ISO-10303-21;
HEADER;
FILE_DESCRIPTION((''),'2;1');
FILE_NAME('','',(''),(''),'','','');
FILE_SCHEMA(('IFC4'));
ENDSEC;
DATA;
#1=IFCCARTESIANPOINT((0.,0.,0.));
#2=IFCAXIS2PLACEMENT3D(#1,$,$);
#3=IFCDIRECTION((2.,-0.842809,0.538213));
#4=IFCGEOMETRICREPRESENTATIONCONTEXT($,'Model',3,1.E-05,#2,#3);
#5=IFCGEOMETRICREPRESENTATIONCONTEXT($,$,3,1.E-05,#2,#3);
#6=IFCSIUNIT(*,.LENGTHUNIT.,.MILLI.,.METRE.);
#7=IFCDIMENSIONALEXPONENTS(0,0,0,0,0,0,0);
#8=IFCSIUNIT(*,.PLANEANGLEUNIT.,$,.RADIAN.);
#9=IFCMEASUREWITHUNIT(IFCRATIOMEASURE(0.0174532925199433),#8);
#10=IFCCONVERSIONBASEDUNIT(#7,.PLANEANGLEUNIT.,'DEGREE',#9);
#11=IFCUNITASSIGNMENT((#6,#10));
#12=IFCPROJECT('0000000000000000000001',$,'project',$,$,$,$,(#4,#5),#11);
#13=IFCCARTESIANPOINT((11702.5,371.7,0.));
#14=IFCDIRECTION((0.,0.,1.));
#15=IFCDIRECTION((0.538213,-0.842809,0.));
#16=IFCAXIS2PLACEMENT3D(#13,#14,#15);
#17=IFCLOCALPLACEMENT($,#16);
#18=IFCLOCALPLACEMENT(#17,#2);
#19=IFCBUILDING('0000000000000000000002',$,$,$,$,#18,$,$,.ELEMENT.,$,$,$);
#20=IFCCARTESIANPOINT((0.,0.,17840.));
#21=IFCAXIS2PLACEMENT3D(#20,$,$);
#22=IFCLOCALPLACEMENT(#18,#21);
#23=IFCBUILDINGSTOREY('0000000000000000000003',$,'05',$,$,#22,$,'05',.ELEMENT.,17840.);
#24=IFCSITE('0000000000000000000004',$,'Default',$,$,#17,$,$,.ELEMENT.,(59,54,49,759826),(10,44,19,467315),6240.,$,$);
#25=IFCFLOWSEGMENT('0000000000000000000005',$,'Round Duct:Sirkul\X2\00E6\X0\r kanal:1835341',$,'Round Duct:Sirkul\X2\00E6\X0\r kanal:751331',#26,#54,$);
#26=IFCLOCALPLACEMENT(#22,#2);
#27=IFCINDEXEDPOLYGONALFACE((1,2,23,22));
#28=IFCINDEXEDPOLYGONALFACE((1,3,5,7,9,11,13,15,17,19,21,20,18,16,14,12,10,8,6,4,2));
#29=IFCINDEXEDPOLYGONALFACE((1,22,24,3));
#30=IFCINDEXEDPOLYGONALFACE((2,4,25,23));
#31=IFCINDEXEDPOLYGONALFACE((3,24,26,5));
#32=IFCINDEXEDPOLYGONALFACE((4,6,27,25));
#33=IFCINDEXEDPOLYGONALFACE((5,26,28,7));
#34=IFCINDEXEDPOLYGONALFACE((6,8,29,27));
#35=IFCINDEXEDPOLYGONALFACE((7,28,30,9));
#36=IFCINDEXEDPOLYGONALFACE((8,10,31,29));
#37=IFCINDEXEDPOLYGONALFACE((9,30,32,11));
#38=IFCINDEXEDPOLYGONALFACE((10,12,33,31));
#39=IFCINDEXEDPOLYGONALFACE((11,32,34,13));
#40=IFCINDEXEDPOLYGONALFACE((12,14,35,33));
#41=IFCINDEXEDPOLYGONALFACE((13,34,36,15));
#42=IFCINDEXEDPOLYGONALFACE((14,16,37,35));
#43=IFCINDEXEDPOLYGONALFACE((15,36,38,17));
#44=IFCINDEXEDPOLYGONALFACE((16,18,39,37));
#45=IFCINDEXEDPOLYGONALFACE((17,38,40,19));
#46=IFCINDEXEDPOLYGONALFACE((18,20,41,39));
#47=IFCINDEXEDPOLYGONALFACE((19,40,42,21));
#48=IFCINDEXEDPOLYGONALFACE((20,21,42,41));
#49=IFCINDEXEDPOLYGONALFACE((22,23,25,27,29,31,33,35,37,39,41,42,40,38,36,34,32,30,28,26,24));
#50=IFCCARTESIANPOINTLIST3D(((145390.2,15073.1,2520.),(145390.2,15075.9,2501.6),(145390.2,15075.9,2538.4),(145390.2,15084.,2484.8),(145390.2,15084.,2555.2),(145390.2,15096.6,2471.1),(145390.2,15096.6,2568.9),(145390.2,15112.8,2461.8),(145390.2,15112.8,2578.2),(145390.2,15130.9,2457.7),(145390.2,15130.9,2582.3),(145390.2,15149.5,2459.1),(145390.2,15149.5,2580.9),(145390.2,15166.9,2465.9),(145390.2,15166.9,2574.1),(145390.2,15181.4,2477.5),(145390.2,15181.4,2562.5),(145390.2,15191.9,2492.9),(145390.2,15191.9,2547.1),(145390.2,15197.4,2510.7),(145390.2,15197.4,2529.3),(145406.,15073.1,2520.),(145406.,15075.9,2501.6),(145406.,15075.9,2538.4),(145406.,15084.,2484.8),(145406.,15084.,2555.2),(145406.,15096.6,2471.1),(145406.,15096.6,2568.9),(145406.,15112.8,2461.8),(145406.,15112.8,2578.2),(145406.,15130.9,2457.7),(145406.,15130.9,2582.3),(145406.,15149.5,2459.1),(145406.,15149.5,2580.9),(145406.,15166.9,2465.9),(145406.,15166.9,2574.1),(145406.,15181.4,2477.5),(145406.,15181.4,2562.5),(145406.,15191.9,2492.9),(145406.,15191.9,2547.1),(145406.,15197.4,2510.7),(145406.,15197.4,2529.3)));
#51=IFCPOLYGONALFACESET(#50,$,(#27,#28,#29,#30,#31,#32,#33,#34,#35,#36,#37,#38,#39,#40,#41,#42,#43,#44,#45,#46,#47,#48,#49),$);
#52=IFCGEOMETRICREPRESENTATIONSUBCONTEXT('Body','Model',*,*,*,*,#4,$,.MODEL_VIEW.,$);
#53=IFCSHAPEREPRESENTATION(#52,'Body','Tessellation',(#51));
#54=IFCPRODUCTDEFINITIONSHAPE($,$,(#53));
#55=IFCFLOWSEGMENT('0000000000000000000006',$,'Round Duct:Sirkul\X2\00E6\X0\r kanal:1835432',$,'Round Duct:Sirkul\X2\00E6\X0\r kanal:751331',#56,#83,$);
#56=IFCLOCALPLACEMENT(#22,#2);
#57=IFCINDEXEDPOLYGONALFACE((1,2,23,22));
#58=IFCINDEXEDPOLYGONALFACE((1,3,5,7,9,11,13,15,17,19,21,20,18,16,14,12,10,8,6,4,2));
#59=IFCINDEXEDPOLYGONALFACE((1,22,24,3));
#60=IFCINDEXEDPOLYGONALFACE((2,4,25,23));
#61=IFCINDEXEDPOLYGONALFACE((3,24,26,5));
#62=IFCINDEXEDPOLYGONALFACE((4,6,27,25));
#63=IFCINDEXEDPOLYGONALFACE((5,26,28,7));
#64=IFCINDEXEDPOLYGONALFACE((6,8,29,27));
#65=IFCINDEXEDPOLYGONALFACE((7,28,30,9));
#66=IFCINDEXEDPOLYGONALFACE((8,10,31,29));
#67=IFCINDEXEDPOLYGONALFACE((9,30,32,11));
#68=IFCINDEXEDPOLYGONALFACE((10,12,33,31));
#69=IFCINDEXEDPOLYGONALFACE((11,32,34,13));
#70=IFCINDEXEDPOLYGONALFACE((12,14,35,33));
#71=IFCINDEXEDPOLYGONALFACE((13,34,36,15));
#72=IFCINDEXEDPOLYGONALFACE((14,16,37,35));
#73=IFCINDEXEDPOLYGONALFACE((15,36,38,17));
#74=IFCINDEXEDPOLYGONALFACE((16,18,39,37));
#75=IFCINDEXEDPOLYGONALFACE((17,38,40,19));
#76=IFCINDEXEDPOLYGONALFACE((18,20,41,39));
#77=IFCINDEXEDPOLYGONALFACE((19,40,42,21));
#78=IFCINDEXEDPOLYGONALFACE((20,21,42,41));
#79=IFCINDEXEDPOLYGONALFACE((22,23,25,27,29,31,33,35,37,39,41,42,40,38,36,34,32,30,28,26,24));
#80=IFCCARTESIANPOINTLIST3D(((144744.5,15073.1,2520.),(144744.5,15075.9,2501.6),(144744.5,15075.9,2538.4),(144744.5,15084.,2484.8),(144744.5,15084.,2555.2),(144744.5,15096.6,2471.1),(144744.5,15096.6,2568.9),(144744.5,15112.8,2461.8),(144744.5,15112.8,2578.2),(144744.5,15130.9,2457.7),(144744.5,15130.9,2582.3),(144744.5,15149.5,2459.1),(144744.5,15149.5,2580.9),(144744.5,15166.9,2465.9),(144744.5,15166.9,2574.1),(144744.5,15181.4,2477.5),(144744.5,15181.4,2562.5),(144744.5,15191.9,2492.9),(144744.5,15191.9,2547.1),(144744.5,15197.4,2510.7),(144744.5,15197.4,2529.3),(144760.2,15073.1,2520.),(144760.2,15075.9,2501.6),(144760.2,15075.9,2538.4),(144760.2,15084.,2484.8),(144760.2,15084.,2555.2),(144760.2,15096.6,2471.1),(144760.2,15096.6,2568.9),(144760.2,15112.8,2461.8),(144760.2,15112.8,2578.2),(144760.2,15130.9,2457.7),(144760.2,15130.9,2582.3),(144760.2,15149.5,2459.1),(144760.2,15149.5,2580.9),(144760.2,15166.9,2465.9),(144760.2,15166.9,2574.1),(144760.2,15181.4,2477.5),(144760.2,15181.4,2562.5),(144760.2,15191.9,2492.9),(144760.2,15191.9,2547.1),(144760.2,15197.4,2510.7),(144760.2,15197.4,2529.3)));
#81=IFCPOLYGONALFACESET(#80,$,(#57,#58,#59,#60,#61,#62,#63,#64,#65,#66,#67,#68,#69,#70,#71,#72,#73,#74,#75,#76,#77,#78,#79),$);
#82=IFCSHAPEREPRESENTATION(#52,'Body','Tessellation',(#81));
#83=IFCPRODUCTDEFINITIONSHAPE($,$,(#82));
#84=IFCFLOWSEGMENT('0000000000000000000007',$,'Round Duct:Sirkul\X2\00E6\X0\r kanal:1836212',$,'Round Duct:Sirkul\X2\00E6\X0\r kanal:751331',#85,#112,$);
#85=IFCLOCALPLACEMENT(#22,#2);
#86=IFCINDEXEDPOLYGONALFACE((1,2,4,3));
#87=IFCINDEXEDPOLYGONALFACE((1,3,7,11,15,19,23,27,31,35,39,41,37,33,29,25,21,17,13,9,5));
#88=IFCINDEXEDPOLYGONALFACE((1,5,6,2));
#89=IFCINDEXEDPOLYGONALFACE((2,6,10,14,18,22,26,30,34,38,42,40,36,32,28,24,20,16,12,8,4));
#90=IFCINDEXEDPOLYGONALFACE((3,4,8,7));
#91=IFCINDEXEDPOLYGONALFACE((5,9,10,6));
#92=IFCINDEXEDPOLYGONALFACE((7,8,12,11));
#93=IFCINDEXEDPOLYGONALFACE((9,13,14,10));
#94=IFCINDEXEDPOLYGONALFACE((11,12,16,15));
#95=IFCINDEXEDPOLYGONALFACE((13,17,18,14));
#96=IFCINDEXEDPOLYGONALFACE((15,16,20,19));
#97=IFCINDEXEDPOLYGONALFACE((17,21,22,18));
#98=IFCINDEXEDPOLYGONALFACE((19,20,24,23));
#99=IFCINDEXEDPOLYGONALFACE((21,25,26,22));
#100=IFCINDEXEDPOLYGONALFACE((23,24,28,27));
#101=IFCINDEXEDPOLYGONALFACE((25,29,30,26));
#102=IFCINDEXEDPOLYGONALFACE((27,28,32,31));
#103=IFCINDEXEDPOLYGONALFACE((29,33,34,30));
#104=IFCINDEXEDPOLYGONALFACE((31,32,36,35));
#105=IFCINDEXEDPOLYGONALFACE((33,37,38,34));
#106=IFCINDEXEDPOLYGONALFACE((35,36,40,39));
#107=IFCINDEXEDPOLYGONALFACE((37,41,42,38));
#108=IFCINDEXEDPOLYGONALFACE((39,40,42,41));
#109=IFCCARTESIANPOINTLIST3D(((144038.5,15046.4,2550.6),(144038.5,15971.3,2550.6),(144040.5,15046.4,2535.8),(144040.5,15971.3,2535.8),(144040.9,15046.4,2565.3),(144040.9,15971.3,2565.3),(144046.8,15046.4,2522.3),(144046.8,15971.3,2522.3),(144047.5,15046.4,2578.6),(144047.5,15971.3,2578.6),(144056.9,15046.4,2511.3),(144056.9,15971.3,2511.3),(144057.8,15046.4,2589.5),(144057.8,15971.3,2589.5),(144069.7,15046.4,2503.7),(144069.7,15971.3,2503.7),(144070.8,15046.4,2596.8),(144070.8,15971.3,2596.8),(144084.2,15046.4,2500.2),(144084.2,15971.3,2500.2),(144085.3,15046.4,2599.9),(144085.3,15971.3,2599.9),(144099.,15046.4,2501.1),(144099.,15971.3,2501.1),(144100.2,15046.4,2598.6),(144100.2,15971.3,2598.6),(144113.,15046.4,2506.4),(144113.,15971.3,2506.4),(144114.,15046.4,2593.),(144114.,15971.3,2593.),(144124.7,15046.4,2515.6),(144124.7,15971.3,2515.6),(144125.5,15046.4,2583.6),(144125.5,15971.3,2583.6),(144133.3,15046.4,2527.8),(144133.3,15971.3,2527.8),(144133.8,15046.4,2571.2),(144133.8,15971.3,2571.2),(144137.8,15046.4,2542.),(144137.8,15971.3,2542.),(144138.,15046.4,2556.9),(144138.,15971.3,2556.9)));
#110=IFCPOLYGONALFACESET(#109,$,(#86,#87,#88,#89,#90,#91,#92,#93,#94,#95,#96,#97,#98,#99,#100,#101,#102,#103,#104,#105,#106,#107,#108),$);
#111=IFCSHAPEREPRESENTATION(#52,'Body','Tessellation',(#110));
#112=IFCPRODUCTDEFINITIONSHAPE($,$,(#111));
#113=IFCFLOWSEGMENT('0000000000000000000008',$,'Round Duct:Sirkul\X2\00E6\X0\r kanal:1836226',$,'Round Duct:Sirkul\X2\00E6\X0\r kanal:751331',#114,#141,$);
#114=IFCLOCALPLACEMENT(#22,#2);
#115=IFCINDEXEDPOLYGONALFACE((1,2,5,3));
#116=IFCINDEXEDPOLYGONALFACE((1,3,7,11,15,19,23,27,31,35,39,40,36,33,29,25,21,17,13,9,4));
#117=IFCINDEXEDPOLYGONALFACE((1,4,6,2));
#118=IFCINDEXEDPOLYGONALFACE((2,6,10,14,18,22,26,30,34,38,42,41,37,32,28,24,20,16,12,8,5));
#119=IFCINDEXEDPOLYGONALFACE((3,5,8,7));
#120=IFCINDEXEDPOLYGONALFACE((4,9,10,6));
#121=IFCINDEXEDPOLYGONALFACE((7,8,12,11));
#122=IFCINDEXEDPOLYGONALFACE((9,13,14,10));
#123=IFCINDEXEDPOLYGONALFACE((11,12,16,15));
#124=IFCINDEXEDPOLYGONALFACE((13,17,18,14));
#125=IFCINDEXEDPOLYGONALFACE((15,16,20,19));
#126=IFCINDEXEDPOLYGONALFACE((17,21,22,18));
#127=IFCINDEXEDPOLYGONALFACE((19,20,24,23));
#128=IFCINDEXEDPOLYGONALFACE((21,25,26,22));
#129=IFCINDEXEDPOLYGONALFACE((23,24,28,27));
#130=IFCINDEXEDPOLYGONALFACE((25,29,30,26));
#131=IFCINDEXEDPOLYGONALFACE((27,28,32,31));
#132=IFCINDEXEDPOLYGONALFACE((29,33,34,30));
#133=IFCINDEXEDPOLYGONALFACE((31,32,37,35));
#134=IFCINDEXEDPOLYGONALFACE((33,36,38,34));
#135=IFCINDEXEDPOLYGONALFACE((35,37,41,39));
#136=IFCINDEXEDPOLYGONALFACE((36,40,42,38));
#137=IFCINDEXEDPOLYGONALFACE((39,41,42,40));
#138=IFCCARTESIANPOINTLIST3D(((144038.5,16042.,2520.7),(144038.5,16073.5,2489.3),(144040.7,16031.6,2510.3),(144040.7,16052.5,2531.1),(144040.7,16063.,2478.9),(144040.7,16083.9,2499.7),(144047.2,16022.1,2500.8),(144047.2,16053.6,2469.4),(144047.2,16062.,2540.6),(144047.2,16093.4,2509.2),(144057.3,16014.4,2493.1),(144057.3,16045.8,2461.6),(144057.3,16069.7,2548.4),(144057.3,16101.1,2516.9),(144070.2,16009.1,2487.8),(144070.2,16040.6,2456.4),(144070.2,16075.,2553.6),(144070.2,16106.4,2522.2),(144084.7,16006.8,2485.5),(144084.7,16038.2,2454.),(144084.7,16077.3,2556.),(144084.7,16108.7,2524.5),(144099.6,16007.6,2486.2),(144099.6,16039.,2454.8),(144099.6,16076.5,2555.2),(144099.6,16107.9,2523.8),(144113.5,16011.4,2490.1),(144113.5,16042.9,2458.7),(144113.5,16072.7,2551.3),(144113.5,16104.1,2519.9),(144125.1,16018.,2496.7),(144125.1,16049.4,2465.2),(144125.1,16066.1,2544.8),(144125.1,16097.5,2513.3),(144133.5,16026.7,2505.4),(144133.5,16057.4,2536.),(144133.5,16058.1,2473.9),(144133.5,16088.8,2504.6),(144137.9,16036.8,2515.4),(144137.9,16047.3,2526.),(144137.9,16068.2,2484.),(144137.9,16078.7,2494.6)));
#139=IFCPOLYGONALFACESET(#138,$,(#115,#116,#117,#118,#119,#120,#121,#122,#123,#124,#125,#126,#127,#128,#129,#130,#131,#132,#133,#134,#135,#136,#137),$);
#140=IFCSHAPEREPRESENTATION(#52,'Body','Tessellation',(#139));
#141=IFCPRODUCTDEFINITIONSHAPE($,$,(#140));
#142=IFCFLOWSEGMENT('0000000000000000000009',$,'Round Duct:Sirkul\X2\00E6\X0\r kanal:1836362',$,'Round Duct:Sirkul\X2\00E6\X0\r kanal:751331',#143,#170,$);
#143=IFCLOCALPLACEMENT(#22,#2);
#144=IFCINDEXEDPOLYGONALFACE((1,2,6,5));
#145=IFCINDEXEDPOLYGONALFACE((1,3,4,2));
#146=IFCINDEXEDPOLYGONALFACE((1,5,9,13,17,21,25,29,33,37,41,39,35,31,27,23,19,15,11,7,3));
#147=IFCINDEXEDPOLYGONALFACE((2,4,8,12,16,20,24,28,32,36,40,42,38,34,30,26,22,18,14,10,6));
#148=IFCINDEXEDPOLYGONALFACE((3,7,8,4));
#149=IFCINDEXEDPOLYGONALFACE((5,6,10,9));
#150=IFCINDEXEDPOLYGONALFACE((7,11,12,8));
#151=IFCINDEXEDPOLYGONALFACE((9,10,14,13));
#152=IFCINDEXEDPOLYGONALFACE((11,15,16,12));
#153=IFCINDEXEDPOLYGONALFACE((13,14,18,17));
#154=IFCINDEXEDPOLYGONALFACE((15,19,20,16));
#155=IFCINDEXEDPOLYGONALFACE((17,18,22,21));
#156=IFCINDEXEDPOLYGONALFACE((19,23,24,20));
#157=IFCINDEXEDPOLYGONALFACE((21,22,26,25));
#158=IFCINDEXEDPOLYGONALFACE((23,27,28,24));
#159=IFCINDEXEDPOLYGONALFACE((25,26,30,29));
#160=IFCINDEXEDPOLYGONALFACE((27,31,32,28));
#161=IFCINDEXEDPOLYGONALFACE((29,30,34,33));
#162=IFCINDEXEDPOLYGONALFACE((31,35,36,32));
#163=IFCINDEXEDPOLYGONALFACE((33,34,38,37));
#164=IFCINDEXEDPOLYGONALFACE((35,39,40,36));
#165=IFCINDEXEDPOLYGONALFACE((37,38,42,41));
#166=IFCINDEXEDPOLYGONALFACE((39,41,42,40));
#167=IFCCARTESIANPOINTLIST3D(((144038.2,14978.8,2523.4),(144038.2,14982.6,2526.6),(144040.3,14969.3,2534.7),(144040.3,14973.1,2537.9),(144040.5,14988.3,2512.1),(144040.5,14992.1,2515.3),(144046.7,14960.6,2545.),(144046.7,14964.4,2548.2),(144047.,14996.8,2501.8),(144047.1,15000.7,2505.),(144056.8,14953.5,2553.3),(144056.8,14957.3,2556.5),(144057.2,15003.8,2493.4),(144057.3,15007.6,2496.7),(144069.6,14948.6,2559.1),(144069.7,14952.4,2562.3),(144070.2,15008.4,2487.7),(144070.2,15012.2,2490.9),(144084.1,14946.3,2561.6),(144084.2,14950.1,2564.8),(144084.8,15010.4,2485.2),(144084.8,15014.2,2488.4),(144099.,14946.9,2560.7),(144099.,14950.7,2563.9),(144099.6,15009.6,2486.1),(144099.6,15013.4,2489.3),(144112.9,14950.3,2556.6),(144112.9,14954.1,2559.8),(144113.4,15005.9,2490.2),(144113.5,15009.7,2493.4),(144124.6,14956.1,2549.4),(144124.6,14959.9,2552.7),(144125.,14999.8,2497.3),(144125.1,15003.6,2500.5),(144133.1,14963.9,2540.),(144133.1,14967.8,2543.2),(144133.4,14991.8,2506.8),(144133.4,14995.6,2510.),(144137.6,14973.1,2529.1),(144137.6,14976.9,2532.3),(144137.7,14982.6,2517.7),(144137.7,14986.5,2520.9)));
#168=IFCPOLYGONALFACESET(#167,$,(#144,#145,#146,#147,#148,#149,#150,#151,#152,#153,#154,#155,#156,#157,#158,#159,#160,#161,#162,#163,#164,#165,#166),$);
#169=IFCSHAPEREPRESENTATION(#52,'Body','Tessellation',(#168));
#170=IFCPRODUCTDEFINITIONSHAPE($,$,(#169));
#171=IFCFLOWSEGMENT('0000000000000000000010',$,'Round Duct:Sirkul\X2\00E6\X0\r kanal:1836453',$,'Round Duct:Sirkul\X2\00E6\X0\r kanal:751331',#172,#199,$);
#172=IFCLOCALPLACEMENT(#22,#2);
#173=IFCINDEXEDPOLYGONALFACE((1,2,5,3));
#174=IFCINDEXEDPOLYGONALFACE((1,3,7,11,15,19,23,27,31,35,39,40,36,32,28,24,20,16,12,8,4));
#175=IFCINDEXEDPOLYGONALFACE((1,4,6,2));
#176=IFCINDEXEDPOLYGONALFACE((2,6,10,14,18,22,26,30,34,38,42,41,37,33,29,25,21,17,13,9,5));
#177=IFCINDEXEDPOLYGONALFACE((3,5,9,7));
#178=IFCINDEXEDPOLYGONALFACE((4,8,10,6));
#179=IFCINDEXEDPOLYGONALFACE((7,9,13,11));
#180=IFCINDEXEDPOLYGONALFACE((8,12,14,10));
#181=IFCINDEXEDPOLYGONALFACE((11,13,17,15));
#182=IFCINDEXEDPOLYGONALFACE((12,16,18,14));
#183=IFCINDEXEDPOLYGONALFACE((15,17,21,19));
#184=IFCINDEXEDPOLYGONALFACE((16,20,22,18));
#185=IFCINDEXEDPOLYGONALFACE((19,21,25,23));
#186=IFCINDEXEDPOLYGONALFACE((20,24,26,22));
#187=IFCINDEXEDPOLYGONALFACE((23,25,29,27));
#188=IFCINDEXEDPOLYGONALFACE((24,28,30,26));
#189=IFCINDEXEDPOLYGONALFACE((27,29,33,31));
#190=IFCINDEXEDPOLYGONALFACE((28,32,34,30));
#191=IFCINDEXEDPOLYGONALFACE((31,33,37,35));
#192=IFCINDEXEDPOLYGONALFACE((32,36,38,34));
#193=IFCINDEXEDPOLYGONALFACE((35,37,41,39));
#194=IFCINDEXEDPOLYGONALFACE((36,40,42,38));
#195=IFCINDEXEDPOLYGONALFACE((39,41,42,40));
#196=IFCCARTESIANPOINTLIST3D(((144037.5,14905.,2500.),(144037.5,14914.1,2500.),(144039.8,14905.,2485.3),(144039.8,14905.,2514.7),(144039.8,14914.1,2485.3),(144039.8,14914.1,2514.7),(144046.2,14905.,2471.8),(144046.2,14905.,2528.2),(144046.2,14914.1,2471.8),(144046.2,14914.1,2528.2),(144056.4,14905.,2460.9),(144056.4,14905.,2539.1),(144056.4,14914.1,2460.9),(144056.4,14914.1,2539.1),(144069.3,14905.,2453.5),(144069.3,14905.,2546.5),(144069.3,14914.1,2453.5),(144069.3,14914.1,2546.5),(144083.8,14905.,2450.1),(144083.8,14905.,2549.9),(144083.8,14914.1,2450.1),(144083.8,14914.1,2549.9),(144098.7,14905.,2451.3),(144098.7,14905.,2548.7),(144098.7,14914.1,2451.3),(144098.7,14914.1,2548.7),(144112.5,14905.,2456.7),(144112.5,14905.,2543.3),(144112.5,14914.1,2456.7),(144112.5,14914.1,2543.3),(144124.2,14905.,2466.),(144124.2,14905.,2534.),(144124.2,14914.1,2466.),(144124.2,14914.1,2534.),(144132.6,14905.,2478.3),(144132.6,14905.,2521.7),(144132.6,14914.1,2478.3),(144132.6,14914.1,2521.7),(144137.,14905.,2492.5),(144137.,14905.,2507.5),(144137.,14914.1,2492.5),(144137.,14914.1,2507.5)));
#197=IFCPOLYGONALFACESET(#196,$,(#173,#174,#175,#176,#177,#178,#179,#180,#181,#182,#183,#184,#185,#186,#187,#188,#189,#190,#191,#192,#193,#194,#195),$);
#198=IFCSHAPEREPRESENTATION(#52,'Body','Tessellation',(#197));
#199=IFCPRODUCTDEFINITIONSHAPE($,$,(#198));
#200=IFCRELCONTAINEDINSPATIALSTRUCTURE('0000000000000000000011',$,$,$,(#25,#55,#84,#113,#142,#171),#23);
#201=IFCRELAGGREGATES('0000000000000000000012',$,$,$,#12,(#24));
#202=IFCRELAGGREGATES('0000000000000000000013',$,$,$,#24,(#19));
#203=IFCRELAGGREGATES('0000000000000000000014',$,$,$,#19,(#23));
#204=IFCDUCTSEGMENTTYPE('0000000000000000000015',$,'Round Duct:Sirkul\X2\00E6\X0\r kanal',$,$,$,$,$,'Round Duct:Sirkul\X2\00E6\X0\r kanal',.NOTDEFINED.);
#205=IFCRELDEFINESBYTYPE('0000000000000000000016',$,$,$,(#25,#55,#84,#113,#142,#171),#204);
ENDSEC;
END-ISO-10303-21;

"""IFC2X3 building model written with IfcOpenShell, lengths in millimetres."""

from ifc_helpers import new_model, entity, si_unit, converted_unit, direction, frame, frame_2d, origin, origin_2d_with_axis, place, context, subcontext, project, spatial, circle, extrude, type_object, element, save


model = new_model("IFC2X3")

# Units and contexts
model_context = context("Model", 3, precision=1e-05, world=origin(), true_north=direction((2.0, -0.842809, 0.538213)))
context_of_model = context(None, 3, precision=1e-05, world=origin(), true_north=direction((2.0, -0.842809, 0.538213)))
body_context = subcontext(model_context, "Body", "Model", "MODEL_VIEW")
ifc_project = project(units=[si_unit("LENGTHUNIT", "METRE", prefix="MILLI"), converted_unit("PLANEANGLEUNIT", "DEGREE", entity("IfcRatioMeasure", 0.0174532925199433), si_unit("PLANEANGLEUNIT", "RADIAN"), dimensions=[0, 0, 0, 0, 0, 0, 0])], contexts=[model_context, context_of_model])

# Site, building, storey
site_placement = place(None, frame((11702.5, 371.7, 0.0), z_axis=(0.0, 0.0, 1.0), x_axis=(0.538213, -0.842809, 0.0)))
site = spatial("IfcSite", under=ifc_project, at=site_placement, Name="Default", CompositionType="ELEMENT", RefLatitude=(59, 54, 49, 759826), RefLongitude=(10, 44, 19, 467315), RefElevation=6240.0)
building_placement = place(site_placement, origin())
building = spatial("IfcBuilding", under=site, at=building_placement, CompositionType="ELEMENT")
storey_placement = place(building_placement, frame((0.0, 0.0, 17840.0)))
storey = spatial("IfcBuildingStorey", under=building, at=storey_placement, Name="05", LongName="05", CompositionType="ELEMENT", Elevation=17840.0)

# Flow segments
duct_segment_type_1 = type_object("IfcDuctSegmentType", Name="Round Duct:Sirkulær kanal", ElementType="Round Duct:Sirkulær kanal", PredefinedType="NOTDEFINED")
flow_segment_1_placement = place(storey_placement, origin())
element("IfcFlowSegment", 1, at=flow_segment_1_placement, inside=storey, type_object=duct_segment_type_1, Name="Round Duct:Sirkulær kanal:1835341", ObjectType="Round Duct:Sirkulær kanal:751331", context=body_context, shape_type="SweptSolid", body=[
    extrude(circle(Radius=62.5, at=frame_2d((0.0, 0.0), x_axis=(1.0, 0.0))), frame((145390.2, 15135.6, 2520.0), z_axis=(1.0, 0.0, 0.0), x_axis=(0.0, -1.0, 0.0)), (0.0, 0.0, 1.0), 15.7),
])
flow_segment_2_placement = place(storey_placement, origin())
element("IfcFlowSegment", 2, at=flow_segment_2_placement, inside=storey, type_object=duct_segment_type_1, Name="Round Duct:Sirkulær kanal:1835432", ObjectType="Round Duct:Sirkulær kanal:751331", context=body_context, shape_type="SweptSolid", body=[
    extrude(circle(Radius=62.5, at=frame_2d((0.0, 0.0), x_axis=(1.0, 0.0))), frame((144744.5, 15135.6, 2520.0), z_axis=(1.0, 0.0, 0.0), x_axis=(0.0, -1.0, 0.0)), (0.0, 0.0, 1.0), 15.7),
])
flow_segment_3_placement = place(storey_placement, origin())
element("IfcFlowSegment", 3, at=flow_segment_3_placement, inside=storey, type_object=duct_segment_type_1, Name="Round Duct:Sirkulær kanal:1836212", ObjectType="Round Duct:Sirkulær kanal:751331", context=body_context, shape_type="SweptSolid", body=[
    extrude(circle(Radius=50.0, at=frame_2d((0.0, 0.0), x_axis=(1.0, 0.0))), frame((144088.5, 15971.3, 2550.0), z_axis=(0.0, -1.0, 0.0), x_axis=(-0.999932, 0.0, 0.011691)), (0.0, 0.0, 1.0), 924.9),
])
flow_segment_4_placement = place(storey_placement, origin())
element("IfcFlowSegment", 4, at=flow_segment_4_placement, inside=storey, type_object=duct_segment_type_1, Name="Round Duct:Sirkulær kanal:1836226", ObjectType="Round Duct:Sirkulær kanal:751331", context=body_context, shape_type="SweptSolid", body=[
    extrude(circle(Radius=50.0, at=origin_2d_with_axis()), frame((144088.5, 16042.0, 2520.7), z_axis=(0.0, 0.707106, -0.707107), x_axis=(-1.0, 0.0, 0.0)), (0.0, 0.0, 1.0), 44.4),
])
flow_segment_5_placement = place(storey_placement, origin())
element("IfcFlowSegment", 5, at=flow_segment_5_placement, inside=storey, type_object=duct_segment_type_1, Name="Round Duct:Sirkulær kanal:1836362", ObjectType="Round Duct:Sirkulær kanal:751331", context=body_context, shape_type="SweptSolid", body=[
    extrude(circle(Radius=50.0, at=frame_2d((0.0, 0.0), x_axis=(1.0, 0.0))), frame((144088.2, 14978.3, 2523.4), z_axis=(0.007515, 0.766008, 0.642788), x_axis=(-0.999952, 0.00981, 0.0)), (0.0, 0.0, 1.0), 5.0),
])
flow_segment_6_placement = place(storey_placement, origin())
element("IfcFlowSegment", 6, at=flow_segment_6_placement, inside=storey, type_object=duct_segment_type_1, Name="Round Duct:Sirkulær kanal:1836453", ObjectType="Round Duct:Sirkulær kanal:751331", context=body_context, shape_type="SweptSolid", body=[
    extrude(circle(Radius=50.0, at=origin_2d_with_axis()), frame((144087.5, 14905.0, 2500.0), z_axis=(0.0, 1.0, 0.0), x_axis=(-1.0, 0.0, 0.0)), (0.0, 0.0, 1.0), 9.0),
])

save(model, "model.ifc")
